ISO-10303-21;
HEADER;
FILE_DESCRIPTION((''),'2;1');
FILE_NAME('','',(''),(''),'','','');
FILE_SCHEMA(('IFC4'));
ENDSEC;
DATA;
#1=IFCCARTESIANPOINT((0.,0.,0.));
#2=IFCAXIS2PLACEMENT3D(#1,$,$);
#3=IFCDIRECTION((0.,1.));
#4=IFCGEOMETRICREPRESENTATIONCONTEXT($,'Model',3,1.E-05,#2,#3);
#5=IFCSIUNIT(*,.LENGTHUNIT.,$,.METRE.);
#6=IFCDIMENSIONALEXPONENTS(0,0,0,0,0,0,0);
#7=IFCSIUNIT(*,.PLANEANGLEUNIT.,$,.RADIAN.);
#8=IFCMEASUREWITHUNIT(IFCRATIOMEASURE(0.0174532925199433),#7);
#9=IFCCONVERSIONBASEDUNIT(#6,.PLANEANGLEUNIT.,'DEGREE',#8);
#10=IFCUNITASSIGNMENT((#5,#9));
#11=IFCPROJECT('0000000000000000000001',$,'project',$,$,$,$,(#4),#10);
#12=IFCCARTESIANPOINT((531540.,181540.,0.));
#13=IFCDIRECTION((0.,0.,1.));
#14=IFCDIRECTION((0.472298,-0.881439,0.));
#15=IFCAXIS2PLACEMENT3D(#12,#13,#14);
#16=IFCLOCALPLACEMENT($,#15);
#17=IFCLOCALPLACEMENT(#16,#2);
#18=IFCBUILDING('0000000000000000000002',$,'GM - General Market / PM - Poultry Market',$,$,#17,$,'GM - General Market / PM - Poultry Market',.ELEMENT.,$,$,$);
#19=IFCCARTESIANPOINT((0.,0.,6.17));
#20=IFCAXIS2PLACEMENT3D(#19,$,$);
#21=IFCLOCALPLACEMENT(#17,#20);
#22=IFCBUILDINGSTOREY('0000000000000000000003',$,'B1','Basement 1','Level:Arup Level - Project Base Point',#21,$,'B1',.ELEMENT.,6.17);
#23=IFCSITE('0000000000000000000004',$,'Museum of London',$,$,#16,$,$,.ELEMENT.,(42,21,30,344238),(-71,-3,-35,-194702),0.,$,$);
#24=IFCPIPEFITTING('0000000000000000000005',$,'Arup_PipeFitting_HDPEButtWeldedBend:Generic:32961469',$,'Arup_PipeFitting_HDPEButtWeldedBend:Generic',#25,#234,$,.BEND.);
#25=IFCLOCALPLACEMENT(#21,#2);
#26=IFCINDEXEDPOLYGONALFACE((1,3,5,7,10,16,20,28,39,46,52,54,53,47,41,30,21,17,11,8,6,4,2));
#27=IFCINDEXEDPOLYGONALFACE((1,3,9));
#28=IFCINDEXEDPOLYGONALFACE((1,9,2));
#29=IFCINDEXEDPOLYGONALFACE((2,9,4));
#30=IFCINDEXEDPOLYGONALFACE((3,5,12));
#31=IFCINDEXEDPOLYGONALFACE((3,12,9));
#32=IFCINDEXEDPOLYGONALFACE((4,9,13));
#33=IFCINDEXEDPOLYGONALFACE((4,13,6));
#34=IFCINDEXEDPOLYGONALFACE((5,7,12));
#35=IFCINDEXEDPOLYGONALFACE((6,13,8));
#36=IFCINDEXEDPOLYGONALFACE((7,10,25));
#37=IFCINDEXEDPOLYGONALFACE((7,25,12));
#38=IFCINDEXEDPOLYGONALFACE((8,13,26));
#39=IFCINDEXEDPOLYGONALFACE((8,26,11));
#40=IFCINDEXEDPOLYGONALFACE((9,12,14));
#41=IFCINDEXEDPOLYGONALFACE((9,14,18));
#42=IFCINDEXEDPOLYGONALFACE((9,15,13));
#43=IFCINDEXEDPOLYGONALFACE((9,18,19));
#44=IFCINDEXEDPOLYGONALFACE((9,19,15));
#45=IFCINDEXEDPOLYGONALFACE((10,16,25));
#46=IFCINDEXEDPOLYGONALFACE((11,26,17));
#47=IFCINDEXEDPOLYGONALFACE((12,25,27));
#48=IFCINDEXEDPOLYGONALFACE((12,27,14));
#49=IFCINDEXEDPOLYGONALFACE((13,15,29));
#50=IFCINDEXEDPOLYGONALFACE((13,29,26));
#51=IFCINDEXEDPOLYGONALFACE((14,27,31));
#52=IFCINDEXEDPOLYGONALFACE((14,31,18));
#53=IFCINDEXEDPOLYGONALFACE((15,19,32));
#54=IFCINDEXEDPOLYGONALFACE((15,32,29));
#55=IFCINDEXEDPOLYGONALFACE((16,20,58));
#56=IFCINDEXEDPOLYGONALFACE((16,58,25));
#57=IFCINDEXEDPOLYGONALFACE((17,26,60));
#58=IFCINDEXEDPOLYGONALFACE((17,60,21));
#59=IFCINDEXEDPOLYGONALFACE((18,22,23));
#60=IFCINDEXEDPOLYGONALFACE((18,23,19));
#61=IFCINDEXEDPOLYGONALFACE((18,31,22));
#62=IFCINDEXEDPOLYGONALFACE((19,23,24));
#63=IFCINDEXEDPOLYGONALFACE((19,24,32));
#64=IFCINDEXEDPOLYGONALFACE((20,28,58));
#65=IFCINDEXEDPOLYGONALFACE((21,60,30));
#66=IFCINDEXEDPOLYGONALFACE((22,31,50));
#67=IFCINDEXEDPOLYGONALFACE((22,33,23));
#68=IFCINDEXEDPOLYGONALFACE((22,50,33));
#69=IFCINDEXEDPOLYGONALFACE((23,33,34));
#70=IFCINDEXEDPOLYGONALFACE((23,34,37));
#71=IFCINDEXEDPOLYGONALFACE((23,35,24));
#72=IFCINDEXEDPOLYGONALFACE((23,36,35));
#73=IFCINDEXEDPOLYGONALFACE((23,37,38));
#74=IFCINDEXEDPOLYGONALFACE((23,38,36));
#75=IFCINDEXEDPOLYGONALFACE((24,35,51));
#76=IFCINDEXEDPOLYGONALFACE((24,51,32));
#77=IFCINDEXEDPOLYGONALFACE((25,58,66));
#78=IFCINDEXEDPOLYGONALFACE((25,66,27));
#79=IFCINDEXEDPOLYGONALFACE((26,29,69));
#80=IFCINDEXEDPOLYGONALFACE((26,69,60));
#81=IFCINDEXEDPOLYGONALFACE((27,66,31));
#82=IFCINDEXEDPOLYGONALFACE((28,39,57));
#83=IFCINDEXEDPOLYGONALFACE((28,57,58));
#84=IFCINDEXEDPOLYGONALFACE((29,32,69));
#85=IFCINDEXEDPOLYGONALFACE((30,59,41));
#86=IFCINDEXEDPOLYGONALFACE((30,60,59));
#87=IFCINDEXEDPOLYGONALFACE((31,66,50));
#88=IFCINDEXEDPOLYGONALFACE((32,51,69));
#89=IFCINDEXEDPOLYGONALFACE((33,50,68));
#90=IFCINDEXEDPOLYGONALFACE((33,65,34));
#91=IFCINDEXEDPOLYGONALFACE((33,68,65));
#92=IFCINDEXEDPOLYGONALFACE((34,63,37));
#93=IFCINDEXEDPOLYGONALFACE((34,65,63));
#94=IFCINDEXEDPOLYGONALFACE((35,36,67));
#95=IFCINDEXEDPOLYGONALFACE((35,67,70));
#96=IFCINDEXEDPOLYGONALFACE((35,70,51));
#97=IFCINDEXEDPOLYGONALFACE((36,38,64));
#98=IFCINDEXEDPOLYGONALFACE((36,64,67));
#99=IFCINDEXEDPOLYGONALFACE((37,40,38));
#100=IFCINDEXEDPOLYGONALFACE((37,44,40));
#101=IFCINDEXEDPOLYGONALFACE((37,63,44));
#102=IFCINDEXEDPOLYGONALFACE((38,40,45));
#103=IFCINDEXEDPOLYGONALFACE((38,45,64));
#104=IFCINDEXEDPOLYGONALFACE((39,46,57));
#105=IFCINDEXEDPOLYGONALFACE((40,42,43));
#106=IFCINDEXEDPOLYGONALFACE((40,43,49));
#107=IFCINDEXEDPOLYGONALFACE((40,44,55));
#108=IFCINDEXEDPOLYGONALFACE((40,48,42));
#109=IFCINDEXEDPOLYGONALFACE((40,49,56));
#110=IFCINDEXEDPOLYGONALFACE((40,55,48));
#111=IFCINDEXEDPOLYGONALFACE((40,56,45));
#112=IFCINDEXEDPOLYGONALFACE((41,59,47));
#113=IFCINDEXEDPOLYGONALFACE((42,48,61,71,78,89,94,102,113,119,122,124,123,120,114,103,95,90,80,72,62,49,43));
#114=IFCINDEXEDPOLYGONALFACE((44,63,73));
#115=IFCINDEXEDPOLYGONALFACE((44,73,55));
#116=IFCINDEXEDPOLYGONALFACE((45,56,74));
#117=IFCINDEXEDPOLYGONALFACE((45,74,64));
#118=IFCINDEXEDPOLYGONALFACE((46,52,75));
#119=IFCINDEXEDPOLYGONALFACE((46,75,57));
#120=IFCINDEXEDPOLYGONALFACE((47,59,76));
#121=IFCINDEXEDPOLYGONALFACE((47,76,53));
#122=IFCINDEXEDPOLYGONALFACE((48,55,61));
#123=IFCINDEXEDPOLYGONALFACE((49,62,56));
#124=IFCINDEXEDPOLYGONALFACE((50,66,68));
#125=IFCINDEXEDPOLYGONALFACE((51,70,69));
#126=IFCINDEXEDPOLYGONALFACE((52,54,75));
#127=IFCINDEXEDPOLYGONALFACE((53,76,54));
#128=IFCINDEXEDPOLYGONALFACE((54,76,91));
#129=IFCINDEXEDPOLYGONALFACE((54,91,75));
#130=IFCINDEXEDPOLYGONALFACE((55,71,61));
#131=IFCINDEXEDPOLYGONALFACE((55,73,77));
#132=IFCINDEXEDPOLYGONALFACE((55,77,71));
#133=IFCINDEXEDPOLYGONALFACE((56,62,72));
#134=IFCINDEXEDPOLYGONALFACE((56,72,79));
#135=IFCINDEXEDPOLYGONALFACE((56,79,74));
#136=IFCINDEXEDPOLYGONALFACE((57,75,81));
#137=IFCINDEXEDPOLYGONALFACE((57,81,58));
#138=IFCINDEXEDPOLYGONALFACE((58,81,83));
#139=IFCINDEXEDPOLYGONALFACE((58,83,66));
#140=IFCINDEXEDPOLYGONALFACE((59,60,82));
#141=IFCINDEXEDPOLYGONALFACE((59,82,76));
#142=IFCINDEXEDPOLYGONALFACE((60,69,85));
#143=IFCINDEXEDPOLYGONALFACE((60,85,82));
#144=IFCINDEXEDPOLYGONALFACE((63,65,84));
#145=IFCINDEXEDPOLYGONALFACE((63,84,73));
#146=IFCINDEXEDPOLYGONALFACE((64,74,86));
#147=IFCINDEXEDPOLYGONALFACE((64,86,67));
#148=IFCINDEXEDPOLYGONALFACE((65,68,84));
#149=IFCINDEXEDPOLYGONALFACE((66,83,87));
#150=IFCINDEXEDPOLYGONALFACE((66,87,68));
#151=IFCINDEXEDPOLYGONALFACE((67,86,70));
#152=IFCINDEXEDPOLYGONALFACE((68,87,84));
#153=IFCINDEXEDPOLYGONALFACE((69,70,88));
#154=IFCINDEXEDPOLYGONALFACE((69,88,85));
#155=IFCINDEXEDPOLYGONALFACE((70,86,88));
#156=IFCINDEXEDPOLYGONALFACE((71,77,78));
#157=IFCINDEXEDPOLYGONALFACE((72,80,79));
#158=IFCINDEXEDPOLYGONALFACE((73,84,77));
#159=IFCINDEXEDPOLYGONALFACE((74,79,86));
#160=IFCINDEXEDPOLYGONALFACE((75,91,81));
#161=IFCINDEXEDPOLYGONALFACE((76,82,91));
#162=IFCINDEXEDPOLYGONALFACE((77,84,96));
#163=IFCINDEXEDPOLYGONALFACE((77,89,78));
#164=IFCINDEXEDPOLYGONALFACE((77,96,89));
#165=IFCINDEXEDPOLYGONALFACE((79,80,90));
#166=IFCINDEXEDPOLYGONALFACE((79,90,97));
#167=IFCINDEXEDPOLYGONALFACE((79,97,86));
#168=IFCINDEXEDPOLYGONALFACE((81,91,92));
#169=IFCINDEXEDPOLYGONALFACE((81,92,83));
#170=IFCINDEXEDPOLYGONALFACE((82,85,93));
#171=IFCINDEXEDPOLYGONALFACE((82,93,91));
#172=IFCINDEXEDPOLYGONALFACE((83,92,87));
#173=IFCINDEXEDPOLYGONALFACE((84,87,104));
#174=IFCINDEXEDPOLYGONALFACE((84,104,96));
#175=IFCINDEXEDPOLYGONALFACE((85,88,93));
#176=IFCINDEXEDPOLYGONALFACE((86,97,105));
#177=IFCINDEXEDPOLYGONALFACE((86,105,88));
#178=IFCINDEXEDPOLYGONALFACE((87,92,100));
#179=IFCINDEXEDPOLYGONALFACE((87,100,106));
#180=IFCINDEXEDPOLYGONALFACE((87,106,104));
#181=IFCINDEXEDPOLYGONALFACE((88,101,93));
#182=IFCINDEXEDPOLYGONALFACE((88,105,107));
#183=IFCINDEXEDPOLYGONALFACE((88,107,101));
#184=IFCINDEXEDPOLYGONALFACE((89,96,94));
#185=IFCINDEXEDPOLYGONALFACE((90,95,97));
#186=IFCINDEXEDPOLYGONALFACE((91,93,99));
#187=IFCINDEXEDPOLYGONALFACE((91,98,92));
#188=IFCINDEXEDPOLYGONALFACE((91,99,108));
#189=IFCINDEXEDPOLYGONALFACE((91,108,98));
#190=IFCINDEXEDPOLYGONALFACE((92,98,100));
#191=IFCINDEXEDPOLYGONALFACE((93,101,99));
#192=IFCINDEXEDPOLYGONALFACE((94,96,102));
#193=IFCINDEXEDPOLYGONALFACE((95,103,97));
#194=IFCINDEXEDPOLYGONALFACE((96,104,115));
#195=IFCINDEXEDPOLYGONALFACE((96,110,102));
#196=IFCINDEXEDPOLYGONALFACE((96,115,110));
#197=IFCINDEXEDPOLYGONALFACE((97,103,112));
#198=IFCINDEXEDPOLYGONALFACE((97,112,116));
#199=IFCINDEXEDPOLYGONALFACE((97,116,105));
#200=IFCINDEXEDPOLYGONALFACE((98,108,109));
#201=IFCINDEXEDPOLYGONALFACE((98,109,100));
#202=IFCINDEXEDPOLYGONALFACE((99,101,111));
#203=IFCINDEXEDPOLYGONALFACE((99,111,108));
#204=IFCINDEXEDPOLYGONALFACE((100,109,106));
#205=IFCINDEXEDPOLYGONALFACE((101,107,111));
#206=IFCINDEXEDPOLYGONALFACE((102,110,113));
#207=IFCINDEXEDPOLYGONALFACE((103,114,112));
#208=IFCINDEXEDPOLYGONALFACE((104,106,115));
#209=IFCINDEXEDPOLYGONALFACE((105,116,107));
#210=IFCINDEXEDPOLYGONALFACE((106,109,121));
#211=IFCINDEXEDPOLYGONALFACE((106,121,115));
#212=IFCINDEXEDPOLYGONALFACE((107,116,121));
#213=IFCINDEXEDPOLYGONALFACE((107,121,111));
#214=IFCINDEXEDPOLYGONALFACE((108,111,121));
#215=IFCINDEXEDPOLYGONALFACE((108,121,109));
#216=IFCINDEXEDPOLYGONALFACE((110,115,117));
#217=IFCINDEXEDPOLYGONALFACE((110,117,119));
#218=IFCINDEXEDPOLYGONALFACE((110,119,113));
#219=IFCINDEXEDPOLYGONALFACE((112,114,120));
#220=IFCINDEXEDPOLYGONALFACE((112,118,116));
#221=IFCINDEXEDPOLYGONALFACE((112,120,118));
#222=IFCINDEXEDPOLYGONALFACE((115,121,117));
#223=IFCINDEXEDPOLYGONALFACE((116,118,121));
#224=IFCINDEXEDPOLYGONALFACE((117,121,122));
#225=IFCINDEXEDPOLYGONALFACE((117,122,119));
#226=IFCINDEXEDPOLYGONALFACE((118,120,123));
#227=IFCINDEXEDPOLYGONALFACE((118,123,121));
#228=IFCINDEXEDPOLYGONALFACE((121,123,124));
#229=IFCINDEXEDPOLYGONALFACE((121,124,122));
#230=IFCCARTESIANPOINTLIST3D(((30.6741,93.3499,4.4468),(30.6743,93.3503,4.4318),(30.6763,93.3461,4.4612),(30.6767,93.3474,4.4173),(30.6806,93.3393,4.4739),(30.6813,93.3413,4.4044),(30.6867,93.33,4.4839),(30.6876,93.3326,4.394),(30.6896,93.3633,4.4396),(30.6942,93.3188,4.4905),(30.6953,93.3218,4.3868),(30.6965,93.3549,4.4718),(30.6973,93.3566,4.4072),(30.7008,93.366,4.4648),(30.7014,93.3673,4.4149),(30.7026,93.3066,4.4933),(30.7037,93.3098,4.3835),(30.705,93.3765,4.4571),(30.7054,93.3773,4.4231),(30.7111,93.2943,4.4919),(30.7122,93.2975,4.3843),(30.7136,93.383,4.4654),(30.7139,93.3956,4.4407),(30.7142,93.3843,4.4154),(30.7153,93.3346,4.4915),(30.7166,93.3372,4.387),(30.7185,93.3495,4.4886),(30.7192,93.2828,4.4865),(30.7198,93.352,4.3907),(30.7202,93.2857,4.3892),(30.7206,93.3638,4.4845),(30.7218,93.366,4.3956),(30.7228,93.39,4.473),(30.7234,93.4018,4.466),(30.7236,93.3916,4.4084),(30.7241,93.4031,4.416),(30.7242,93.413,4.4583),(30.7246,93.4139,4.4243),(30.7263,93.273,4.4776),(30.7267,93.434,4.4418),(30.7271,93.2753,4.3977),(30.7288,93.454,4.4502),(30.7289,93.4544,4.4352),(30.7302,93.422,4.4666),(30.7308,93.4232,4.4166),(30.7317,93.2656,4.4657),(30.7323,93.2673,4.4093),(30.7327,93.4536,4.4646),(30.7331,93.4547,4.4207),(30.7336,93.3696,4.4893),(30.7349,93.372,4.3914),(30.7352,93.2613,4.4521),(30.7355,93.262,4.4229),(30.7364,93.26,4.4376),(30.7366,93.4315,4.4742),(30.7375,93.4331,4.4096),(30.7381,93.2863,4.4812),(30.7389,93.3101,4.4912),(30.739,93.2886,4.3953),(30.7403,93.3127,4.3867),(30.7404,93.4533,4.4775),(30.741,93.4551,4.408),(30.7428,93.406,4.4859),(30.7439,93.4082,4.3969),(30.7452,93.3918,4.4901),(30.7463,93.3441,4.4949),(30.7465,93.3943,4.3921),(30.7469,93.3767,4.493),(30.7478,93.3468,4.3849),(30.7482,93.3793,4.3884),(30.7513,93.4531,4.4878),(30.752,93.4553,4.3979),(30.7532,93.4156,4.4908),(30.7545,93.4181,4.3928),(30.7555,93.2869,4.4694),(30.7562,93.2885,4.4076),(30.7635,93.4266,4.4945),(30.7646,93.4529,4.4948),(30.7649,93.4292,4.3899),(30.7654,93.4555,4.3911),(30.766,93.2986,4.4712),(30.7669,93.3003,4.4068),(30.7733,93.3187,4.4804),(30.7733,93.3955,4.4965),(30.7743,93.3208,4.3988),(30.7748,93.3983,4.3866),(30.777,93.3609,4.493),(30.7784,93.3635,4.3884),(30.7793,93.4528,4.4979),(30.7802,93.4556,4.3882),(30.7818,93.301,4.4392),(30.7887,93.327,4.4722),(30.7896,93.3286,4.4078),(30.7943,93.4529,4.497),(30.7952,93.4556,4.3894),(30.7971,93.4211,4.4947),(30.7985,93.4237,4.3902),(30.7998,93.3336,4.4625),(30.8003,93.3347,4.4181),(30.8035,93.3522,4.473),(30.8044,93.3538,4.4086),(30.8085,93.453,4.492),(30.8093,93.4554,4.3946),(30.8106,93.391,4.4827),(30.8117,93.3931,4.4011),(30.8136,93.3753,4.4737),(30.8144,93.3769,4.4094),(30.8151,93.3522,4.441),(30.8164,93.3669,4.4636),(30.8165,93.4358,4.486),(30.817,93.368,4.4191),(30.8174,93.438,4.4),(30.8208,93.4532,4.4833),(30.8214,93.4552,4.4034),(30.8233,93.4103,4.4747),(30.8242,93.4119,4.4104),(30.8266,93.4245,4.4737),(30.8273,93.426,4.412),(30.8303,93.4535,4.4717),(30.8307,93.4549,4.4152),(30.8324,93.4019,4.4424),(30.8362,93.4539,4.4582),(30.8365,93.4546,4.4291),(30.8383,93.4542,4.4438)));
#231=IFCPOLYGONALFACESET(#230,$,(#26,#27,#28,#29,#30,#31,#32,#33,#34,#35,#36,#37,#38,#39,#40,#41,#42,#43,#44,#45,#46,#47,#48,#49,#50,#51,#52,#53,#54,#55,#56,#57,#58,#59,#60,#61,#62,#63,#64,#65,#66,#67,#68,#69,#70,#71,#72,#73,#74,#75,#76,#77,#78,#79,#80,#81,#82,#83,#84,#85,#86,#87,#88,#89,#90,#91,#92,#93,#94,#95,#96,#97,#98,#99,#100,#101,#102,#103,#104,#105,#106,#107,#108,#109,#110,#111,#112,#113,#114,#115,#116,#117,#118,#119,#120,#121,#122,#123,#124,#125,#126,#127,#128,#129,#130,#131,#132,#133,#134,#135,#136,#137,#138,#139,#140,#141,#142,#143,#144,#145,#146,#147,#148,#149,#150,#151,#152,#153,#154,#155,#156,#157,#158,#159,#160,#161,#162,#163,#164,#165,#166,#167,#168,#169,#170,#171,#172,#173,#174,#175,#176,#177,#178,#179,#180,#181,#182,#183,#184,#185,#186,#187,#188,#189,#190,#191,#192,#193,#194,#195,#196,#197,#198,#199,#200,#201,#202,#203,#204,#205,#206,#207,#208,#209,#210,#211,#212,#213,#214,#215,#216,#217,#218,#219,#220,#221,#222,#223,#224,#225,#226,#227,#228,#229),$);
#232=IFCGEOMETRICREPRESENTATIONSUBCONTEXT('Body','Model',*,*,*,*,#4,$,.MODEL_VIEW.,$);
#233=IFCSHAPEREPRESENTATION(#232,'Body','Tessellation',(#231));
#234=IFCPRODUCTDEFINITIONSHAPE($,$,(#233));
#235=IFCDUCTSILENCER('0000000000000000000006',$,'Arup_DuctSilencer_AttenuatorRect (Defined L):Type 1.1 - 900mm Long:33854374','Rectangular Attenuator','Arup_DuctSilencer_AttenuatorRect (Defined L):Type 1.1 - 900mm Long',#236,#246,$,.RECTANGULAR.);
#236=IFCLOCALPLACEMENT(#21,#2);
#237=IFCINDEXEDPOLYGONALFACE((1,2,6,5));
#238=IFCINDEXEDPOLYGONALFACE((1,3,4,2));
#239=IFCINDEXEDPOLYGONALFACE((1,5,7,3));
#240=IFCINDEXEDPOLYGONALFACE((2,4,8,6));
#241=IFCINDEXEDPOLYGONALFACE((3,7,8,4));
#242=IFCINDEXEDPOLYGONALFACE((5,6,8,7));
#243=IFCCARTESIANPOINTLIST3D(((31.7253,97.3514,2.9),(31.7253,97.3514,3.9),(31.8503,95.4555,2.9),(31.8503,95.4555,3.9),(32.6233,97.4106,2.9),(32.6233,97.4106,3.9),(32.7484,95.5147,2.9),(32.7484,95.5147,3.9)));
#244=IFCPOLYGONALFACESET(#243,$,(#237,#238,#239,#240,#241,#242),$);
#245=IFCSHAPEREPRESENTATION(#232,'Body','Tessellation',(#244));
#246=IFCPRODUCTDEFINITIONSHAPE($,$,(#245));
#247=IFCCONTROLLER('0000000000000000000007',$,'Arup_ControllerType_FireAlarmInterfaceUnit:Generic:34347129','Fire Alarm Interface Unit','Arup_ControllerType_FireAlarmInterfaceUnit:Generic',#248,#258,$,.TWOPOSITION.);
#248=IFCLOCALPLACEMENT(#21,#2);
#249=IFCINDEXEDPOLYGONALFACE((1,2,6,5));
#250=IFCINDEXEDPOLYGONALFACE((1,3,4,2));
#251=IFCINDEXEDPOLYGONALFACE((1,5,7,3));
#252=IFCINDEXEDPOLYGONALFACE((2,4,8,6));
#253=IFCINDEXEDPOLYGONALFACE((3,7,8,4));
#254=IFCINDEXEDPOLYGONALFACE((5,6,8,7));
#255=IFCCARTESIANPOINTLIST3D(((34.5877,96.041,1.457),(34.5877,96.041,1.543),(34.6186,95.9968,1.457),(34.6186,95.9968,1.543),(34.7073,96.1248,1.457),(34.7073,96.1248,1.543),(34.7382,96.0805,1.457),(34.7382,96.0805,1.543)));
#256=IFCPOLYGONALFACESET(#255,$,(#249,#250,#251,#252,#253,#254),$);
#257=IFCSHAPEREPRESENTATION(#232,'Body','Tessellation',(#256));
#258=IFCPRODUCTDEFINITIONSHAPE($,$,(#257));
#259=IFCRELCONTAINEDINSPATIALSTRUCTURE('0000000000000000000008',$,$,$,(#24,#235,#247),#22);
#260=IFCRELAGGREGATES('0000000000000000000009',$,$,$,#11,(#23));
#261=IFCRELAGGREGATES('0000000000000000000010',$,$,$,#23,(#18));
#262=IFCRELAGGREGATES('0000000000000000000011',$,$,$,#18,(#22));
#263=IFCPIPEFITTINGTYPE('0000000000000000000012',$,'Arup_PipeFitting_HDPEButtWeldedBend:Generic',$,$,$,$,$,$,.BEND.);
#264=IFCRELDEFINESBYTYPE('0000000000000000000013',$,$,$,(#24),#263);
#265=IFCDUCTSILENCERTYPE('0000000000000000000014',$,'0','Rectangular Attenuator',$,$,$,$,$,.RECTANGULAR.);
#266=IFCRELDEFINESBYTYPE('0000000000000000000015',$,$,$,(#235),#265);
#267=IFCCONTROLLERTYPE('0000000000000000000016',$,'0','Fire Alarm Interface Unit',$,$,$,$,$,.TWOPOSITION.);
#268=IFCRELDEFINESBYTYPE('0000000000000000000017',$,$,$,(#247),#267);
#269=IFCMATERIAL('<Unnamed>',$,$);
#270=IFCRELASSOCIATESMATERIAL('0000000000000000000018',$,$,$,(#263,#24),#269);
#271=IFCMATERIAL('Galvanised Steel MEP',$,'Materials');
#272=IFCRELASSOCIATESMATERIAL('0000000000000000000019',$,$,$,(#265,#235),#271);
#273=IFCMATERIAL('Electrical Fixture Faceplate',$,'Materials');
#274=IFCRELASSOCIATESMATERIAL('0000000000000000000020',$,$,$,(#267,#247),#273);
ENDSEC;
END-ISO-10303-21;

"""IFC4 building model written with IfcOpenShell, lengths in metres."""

from ifc_helpers import new_model, entity, si_unit, converted_unit, direction, frame, origin, origin_2d_with_axis, place, context, subcontext, project, spatial, rectangle, extrude, source, transform, mapped, material, type_object, type_shapes, element, save


model = new_model("IFC4")

# Units and contexts
model_context = context("Model", 3, precision=1e-05, world=origin(), true_north=direction((0.0, 1.0)))
body_context = subcontext(model_context, "Body", "Model", "MODEL_VIEW")
ifc_project = project(units=[si_unit("LENGTHUNIT", "METRE"), converted_unit("PLANEANGLEUNIT", "DEGREE", entity("IfcRatioMeasure", 0.0174532925199433), si_unit("PLANEANGLEUNIT", "RADIAN"), dimensions=[0, 0, 0, 0, 0, 0, 0])], contexts=[model_context])

# Site, building, storey
site_placement = place(None, frame((531540.0, 181540.0, 0.0), z_axis=(0.0, 0.0, 1.0), x_axis=(0.472298, -0.881439, 0.0)))
site = spatial("IfcSite", under=ifc_project, at=site_placement, Name="Museum of London", CompositionType="ELEMENT", RefLatitude=(42, 21, 30, 344238), RefLongitude=(-71, -3, -35, -194702), RefElevation=0.0)
building_placement = place(site_placement, origin())
building = spatial("IfcBuilding", under=site, at=building_placement, Name="GM - General Market / PM - Poultry Market", LongName="GM - General Market / PM - Poultry Market", CompositionType="ELEMENT")
storey_placement = place(building_placement, frame((0.0, 0.0, 6.17)))
storey = spatial("IfcBuildingStorey", under=building, at=storey_placement, Name="B1", Description="Basement 1", ObjectType="Level:Arup Level - Project Base Point", LongName="B1", CompositionType="ELEMENT", Elevation=6.17)

# Shared definitions
ifc_material_1 = material(Name="<Unnamed>")

# Shared definitions
ifc_material_2 = material(Name="Galvanised Steel MEP", Category="Materials")

# Pipe fitting
pipe_fitting_type_1 = type_object("IfcPipeFittingType", Name="Arup_PipeFitting_HDPEButtWeldedBend:Generic", PredefinedType="BEND", material=ifc_material_1)
ifc_direction_1 = entity("IfcDirection", [0.0, 0.0, 1.0])
trimmed_curve_1 = entity("IfcTrimmedCurve", entity("IfcCircle", entity("IfcAxis2Placement2D", entity("IfcCartesianPoint", [-0.1811, 0.0]), entity("IfcDirection", [0.0, 1.0])), 0.1811), [entity("IfcParameterValue", 270.0)], [entity("IfcParameterValue", 325.351464)], True, "PARAMETER")
shared_shape_1 = source(origin(), body_context, "Body", "AdvancedSweptSolid", [
    entity("IfcSurfaceCurveSweptAreaSolid", entity("IfcCircleProfileDef", "AREA", None, entity("IfcAxis2Placement2D", entity("IfcCartesianPoint", [0.0, 0.0]), entity("IfcDirection", [1.0, 0.0])), 0.055), entity("IfcAxis2Placement3D", entity("IfcCartesianPoint", [-0.095, 0.0, 0.0]), ifc_direction_1, entity("IfcDirection", [0.0, -1.0, 0.0])), trimmed_curve_1, 0.0, 55.3515, entity("IfcSurfaceOfLinearExtrusion", entity("IfcArbitraryOpenProfileDef", "CURVE", None, trimmed_curve_1), entity("IfcAxis2Placement3D", entity("IfcCartesianPoint", [0.0, 0.0, -0.3048])), ifc_direction_1, 1.0)),
])
type_shapes(pipe_fitting_type_1, [shared_shape_1])
pipe_fitting_1_placement = place(storey_placement, frame((30.7833, 93.3592, 4.4407), z_axis=(-0.013115, -0.02499, 0.999602), x_axis=(0.822584, 0.568094, 0.024995)))
element("IfcPipeFitting", 1, at=pipe_fitting_1_placement, inside=storey, type_object=pipe_fitting_type_1, material=ifc_material_1, Name="Arup_PipeFitting_HDPEButtWeldedBend:Generic:32961469", ObjectType="Arup_PipeFitting_HDPEButtWeldedBend:Generic", PredefinedType="BEND", context=body_context, shape_type="MappedRepresentation", body=[
    mapped(shared_shape_1, transform((0.0, 0.0, 0.0), scale=1.0)),
])

# Duct silencer
duct_silencer_type = type_object("IfcDuctSilencerType", Name="0", Description="Rectangular Attenuator", PredefinedType="RECTANGULAR", material=ifc_material_2)
shared_shape_2 = source(origin(), body_context, "Body", "SweptSolid", [
    extrude(rectangle(XDim=0.9, YDim=1.9, at=origin_2d_with_axis()), frame((0.0, 0.0, -0.5), z_axis=(0.0, 0.0, 1.0), x_axis=(-1.0, 0.0, 0.0)), (0.0, 0.0, 1.0), 1.0),
])
type_shapes(duct_silencer_type, [shared_shape_2])
duct_silencer_placement = place(storey_placement, frame((32.2368, 96.433, 3.4), z_axis=(0.0, 0.0, -1.0), x_axis=(0.997833, 0.065805, 0.0)))
element("IfcDuctSilencer", 2, at=duct_silencer_placement, inside=storey, type_object=duct_silencer_type, material=ifc_material_2, Name="Arup_DuctSilencer_AttenuatorRect (Defined L):Type 1.1 - 900mm Long:33854374", Description="Rectangular Attenuator", ObjectType="Arup_DuctSilencer_AttenuatorRect (Defined L):Type 1.1 - 900mm Long", PredefinedType="RECTANGULAR", context=body_context, shape_type="MappedRepresentation", body=[
    mapped(shared_shape_2, transform((0.0, 0.0, 0.0), scale=1.0)),
])

# Controller
ifc_material_3 = material(Name="Electrical Fixture Faceplate", Category="Materials")
controller_type = type_object("IfcControllerType", Name="0", Description="Fire Alarm Interface Unit", PredefinedType="TWOPOSITION", material=ifc_material_3)
shared_shape_3 = source(origin(), body_context, "Body", "SweptSolid", [
    extrude(rectangle(XDim=0.054, YDim=0.146, at=origin_2d_with_axis()), frame((0.073, 0.027, 0.0), z_axis=(0.0, 0.0, 1.0), x_axis=(0.0, 1.0, 0.0)), (0.0, 0.0, 1.0), 0.086),
])
type_shapes(controller_type, [shared_shape_3])
controller_placement = place(storey_placement, frame((34.7073, 96.1248, 1.457), z_axis=(0.0, 0.0, 1.0), x_axis=(-0.819152, -0.573576, 0.0)))
element("IfcController", 3, at=controller_placement, inside=storey, type_object=controller_type, material=ifc_material_3, Name="Arup_ControllerType_FireAlarmInterfaceUnit:Generic:34347129", Description="Fire Alarm Interface Unit", ObjectType="Arup_ControllerType_FireAlarmInterfaceUnit:Generic", PredefinedType="TWOPOSITION", context=body_context, shape_type="MappedRepresentation", body=[
    mapped(shared_shape_3, transform((0.0, 0.0, 0.0), scale=1.0)),
])

save(model, "model.ifc")
